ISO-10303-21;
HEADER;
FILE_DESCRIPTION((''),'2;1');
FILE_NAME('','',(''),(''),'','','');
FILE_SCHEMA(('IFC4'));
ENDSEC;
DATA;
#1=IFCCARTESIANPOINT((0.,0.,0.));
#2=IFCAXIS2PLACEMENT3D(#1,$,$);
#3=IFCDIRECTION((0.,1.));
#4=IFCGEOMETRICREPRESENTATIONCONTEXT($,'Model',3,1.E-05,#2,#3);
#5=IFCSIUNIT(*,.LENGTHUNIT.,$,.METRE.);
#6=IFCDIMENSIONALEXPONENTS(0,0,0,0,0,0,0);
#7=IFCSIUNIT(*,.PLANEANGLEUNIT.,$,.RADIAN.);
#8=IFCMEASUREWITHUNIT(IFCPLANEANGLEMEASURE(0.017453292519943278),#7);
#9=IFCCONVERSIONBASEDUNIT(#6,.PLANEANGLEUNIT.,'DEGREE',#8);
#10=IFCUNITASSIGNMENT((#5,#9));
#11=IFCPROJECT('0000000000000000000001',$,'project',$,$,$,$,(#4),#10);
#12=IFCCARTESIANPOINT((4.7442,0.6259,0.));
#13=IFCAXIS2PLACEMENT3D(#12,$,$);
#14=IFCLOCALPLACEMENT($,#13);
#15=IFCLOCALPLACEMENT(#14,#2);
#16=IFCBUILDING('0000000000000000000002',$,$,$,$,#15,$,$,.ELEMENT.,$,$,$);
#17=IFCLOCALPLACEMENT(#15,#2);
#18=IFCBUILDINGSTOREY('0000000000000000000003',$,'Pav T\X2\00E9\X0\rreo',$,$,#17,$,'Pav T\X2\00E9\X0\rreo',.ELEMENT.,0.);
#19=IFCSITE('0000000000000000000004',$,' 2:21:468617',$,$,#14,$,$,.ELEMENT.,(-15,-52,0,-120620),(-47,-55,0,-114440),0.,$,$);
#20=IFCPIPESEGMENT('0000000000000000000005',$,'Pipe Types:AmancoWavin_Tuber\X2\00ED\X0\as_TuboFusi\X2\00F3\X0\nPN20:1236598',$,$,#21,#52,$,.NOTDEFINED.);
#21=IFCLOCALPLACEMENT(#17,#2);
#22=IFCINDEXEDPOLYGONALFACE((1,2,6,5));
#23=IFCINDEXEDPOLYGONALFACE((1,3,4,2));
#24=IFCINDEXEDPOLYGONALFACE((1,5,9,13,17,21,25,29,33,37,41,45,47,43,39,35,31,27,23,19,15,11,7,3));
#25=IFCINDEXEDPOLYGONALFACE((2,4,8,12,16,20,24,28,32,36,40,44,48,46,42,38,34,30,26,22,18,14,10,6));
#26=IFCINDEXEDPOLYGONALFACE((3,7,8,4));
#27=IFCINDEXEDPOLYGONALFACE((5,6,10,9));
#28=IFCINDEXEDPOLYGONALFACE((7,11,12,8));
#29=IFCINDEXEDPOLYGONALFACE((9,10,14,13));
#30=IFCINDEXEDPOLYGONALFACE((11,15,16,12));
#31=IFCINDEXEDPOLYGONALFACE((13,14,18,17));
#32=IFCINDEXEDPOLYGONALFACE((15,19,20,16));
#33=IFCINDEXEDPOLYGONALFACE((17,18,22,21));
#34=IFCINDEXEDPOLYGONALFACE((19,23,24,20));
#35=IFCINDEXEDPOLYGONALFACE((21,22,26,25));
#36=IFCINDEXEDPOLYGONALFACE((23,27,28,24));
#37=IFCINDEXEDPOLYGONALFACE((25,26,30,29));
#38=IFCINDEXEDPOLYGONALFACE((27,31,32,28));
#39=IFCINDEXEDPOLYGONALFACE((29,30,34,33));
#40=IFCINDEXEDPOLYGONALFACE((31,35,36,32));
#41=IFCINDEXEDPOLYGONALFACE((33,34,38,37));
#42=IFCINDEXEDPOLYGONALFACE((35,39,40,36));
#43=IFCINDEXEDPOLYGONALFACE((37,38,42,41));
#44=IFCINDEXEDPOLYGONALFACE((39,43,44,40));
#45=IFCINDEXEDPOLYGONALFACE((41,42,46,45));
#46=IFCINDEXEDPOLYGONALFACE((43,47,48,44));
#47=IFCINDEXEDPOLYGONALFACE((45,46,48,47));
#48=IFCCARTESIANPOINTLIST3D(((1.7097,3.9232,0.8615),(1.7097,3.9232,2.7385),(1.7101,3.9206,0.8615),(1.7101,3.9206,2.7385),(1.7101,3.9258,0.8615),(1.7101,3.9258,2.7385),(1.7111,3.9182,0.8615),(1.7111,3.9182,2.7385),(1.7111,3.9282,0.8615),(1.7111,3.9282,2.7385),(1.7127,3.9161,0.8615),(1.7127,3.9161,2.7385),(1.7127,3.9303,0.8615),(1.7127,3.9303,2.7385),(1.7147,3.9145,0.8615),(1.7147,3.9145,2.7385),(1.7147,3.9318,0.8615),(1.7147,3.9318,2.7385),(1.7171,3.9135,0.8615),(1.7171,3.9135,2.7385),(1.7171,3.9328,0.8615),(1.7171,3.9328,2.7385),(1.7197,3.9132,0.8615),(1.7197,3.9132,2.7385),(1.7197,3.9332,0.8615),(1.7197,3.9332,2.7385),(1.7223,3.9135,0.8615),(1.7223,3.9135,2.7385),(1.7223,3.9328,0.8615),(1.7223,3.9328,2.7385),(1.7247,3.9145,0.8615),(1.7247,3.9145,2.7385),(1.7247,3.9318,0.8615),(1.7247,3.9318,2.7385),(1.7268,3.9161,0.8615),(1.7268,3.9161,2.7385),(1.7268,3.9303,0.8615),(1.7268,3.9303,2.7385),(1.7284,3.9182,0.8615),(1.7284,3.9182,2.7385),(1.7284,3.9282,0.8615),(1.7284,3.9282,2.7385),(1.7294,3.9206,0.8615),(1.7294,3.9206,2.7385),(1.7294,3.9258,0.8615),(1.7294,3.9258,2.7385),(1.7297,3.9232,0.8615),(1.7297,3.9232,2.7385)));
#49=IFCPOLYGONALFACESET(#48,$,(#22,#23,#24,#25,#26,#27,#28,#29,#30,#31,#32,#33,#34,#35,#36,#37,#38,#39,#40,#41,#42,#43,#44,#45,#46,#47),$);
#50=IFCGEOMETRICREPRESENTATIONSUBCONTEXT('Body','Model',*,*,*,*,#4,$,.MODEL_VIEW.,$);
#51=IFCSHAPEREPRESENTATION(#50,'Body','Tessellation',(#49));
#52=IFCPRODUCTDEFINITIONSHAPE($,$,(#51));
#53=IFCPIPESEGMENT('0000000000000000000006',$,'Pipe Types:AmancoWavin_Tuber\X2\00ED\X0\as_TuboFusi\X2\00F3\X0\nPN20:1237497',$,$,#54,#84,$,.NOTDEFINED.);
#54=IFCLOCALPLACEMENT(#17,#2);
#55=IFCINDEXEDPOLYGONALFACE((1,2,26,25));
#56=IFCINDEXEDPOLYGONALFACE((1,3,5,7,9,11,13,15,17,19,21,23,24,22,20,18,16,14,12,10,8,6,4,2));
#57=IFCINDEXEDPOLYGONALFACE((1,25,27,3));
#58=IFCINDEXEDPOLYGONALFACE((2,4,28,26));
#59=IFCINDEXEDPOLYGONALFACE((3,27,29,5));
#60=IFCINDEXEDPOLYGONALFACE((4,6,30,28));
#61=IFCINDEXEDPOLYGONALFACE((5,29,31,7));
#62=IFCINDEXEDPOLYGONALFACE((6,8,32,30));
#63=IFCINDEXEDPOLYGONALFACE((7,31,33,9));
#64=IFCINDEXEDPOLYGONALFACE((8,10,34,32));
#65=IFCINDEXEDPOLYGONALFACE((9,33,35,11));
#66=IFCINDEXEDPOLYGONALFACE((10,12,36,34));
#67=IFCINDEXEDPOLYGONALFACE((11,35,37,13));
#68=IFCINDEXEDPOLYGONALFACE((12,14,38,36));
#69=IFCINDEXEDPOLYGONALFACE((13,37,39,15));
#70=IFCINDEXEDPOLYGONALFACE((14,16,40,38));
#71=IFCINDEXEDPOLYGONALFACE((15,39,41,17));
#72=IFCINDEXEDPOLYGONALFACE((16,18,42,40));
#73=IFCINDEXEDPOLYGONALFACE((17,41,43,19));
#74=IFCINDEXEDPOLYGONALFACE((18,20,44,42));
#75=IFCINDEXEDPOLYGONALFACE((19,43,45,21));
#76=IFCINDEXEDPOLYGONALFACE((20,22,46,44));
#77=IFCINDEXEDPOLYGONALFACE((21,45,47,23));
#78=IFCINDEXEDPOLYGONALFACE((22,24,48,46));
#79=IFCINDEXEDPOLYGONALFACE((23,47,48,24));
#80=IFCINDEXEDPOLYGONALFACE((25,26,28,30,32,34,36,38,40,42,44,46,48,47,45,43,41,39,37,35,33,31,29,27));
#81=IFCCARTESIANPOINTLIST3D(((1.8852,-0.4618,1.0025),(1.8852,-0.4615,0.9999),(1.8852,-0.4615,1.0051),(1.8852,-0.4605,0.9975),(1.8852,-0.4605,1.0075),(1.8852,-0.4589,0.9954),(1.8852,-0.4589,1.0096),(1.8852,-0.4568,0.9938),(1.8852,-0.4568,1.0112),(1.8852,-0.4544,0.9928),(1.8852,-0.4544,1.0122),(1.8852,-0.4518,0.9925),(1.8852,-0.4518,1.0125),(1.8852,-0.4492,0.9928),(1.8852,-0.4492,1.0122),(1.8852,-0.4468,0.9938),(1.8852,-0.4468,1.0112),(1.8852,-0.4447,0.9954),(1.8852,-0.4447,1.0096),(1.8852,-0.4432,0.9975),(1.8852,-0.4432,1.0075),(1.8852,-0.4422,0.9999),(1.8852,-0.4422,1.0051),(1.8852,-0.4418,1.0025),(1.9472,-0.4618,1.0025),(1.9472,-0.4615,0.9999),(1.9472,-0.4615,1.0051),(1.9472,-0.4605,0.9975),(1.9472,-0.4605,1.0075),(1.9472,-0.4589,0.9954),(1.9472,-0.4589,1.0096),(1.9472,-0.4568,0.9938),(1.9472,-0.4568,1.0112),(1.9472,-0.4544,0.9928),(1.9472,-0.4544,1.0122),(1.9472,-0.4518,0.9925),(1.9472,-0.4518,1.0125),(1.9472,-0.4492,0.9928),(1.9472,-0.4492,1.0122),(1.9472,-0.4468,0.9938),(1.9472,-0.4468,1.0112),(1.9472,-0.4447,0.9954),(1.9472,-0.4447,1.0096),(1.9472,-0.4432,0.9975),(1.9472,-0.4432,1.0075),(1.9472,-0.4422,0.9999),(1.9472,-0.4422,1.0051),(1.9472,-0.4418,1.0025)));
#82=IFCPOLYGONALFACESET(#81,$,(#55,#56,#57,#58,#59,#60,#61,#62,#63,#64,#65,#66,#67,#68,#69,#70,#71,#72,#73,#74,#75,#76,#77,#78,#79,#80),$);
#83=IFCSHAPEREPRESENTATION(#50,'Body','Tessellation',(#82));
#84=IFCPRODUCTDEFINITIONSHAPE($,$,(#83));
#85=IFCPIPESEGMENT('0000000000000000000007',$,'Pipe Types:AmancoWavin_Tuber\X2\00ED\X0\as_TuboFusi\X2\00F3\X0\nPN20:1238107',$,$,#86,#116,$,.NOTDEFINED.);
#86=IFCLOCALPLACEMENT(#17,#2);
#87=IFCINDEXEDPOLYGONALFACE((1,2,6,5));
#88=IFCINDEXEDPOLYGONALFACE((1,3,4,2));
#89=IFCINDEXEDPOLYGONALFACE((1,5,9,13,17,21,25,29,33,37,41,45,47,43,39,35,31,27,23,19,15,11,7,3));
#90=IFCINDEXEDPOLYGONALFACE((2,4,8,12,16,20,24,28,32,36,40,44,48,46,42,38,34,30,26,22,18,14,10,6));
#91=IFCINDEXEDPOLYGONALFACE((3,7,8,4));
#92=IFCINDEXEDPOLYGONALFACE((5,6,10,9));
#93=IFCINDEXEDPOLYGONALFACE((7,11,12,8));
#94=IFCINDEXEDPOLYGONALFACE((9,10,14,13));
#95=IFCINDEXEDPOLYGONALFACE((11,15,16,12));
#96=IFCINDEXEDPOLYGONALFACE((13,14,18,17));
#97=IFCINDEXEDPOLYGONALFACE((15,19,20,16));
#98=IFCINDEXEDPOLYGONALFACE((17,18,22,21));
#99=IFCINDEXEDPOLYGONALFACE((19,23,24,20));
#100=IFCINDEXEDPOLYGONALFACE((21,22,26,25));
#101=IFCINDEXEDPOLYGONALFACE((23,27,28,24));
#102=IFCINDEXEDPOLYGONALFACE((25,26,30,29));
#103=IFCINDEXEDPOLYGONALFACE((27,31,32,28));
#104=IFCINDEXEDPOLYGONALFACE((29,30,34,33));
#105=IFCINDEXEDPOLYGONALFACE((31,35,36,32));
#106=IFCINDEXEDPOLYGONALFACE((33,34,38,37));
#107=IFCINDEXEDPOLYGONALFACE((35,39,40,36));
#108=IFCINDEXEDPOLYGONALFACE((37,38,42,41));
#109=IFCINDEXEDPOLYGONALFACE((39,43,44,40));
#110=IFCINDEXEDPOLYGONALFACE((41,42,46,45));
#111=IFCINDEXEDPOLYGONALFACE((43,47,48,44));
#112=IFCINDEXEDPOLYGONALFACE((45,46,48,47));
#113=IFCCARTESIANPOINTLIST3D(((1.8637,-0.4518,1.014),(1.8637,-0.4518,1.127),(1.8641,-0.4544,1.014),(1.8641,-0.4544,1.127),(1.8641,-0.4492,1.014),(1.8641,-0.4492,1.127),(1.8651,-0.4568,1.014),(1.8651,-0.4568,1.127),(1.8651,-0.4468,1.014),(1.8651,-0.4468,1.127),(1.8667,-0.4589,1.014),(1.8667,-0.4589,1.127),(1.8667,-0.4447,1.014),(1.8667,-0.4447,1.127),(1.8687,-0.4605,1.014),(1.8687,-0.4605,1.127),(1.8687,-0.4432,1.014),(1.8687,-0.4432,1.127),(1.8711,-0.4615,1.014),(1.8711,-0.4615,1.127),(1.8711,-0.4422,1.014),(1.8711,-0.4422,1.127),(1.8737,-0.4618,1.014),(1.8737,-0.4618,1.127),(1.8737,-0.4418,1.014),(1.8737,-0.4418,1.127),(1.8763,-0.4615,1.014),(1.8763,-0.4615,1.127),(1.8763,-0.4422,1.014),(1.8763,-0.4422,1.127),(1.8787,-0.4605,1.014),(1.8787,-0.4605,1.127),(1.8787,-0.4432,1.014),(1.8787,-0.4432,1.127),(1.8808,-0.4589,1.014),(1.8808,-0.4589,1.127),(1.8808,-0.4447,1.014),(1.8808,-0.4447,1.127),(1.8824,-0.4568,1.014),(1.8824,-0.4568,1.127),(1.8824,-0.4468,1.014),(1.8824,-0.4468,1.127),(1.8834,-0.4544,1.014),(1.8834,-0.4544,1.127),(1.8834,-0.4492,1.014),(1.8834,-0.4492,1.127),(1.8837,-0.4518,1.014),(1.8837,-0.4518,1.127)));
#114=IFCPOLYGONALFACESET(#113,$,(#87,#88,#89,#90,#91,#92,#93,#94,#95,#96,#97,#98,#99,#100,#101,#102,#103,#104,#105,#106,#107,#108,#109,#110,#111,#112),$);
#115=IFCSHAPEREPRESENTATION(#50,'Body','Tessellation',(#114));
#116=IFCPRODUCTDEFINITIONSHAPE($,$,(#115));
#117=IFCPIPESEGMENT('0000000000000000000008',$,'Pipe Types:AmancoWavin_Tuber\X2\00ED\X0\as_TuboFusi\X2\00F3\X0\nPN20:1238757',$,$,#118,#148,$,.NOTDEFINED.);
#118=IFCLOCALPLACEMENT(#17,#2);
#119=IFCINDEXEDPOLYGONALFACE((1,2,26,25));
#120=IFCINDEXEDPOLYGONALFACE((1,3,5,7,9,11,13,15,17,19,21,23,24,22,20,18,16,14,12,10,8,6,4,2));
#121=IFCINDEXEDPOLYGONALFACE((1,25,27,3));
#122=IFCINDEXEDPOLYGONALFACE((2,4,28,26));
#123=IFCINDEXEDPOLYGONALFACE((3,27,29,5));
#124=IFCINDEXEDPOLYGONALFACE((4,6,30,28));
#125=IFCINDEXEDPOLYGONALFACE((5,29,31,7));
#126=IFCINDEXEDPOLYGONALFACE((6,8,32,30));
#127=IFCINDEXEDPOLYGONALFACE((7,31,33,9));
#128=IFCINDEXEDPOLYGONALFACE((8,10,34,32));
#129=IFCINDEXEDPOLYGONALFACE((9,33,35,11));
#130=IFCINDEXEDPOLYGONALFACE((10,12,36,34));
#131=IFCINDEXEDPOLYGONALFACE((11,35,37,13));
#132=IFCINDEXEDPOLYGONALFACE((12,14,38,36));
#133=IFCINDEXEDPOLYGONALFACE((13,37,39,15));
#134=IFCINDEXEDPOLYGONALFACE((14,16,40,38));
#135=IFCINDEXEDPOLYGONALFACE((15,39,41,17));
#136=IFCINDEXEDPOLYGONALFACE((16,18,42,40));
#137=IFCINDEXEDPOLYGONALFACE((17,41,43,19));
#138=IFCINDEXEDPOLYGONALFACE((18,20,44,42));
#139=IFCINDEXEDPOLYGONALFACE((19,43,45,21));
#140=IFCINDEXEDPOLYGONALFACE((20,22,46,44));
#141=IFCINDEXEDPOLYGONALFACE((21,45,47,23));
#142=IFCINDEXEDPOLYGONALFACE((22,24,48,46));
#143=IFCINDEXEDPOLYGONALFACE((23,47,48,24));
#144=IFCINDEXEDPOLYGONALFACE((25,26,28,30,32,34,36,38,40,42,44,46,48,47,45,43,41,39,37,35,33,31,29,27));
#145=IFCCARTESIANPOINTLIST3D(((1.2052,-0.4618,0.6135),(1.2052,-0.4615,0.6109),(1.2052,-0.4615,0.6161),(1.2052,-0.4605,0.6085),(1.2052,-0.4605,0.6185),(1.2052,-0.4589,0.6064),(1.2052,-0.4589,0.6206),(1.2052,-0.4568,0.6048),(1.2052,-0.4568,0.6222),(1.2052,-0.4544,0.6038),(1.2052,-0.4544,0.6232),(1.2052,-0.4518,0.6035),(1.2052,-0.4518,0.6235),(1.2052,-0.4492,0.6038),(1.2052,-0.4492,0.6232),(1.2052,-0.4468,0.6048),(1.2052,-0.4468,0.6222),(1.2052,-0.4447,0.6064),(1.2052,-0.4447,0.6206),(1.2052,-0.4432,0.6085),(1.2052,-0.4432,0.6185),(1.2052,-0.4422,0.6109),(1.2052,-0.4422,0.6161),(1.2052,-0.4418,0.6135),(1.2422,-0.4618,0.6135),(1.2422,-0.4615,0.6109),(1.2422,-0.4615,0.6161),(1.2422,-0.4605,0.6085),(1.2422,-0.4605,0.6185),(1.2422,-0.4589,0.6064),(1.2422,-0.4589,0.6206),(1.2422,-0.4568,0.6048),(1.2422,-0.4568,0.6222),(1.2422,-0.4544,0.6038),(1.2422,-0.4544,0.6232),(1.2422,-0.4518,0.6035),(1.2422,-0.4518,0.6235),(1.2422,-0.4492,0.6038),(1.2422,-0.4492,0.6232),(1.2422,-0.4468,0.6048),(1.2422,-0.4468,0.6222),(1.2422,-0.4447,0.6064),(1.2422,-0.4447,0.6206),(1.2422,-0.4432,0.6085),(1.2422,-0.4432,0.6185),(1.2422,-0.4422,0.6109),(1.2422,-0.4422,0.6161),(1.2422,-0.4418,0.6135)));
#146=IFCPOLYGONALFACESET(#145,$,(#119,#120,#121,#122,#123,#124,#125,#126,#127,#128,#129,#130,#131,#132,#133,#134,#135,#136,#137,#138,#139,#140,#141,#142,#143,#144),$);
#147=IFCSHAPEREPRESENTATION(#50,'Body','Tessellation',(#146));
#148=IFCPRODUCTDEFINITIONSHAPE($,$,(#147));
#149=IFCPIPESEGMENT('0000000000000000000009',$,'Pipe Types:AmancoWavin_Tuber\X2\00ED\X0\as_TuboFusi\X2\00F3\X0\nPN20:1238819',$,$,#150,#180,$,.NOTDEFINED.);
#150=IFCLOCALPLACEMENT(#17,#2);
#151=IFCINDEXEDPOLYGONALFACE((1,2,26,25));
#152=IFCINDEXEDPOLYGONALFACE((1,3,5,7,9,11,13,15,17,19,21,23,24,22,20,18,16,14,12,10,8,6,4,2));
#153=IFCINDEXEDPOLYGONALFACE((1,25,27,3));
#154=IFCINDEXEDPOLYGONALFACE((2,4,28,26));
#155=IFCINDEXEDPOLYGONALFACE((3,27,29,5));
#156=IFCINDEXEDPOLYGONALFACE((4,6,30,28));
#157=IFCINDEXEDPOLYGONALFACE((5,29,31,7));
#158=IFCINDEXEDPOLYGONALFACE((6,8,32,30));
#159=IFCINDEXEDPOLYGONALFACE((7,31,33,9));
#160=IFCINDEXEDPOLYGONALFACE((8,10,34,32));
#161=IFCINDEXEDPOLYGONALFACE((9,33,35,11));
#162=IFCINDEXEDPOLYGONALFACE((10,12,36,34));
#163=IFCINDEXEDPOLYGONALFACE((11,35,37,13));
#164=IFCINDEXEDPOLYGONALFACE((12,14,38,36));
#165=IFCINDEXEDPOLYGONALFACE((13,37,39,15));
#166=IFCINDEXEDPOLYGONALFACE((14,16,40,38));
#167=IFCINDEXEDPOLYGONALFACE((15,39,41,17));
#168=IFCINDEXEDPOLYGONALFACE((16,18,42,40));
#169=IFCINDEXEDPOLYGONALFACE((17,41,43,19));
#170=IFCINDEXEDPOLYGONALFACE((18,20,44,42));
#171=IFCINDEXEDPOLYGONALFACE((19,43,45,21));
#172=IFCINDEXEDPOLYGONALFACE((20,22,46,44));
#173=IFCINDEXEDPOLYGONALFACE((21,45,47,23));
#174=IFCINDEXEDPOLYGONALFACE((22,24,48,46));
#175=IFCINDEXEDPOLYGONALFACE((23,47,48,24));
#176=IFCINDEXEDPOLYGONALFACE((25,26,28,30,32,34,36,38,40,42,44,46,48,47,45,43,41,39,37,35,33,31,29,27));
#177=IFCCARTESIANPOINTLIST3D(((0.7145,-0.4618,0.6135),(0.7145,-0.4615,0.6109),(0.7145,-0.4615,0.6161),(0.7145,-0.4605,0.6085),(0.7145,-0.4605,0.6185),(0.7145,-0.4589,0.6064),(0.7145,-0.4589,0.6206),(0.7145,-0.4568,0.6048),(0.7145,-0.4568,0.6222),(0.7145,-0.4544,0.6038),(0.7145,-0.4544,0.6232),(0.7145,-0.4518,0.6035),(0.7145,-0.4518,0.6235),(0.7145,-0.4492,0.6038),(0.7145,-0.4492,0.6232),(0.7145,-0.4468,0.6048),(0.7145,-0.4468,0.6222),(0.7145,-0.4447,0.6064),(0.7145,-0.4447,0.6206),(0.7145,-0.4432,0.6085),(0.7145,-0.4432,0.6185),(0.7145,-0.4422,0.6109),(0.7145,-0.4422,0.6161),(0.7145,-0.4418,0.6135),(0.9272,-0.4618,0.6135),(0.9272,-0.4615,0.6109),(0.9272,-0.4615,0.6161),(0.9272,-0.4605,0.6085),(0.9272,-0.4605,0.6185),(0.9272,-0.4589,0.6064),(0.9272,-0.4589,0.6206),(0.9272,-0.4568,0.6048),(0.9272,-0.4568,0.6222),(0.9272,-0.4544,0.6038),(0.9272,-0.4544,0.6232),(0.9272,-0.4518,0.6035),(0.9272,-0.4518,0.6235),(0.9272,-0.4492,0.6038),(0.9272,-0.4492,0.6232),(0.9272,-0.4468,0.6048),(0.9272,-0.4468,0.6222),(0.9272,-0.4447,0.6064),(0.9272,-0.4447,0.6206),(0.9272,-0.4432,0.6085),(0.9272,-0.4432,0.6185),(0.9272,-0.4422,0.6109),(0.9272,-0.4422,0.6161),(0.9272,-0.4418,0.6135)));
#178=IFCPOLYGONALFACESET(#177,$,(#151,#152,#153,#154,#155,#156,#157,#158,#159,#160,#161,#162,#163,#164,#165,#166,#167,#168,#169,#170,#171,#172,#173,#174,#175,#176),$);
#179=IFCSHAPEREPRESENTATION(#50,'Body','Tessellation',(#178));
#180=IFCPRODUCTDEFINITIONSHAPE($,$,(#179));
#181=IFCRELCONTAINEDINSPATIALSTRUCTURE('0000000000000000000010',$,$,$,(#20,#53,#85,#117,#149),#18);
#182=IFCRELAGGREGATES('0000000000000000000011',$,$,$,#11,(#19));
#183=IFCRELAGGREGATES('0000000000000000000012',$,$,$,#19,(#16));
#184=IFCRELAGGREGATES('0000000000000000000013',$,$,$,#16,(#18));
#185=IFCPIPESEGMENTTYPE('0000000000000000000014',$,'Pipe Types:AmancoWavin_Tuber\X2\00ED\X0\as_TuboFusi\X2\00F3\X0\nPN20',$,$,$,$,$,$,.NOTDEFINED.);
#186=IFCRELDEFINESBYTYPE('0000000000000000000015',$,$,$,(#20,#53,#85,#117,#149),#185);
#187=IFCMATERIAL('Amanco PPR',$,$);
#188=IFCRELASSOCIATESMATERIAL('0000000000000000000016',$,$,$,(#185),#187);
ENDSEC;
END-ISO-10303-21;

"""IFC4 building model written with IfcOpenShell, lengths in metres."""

from ifc_helpers import new_model, entity, si_unit, converted_unit, direction, frame, origin, place, context, subcontext, project, spatial, arc, indexed_curve, outline, extrude, material, type_object, element, save


model = new_model("IFC4")

# Units and contexts
model_context = context("Model", 3, precision=1e-05, world=origin(), true_north=direction((0.0, 1.0)))
body_context = subcontext(model_context, "Body", "Model", "MODEL_VIEW")
ifc_project = project(units=[si_unit("LENGTHUNIT", "METRE"), converted_unit("PLANEANGLEUNIT", "DEGREE", entity("IfcPlaneAngleMeasure", 0.017453292519943278), si_unit("PLANEANGLEUNIT", "RADIAN"), dimensions=[0, 0, 0, 0, 0, 0, 0])], contexts=[model_context])

# Site, building, storey
site_placement = place(None, frame((4.7442, 0.6259, 0.0)))
site = spatial("IfcSite", under=ifc_project, at=site_placement, Name=" 2:21:468617", CompositionType="ELEMENT", RefLatitude=(-15, -52, 0, -120620), RefLongitude=(-47, -55, 0, -114440), RefElevation=0.0)
building_placement = place(site_placement, origin())
building = spatial("IfcBuilding", under=site, at=building_placement, CompositionType="ELEMENT")
storey_placement = place(building_placement, origin())
storey = spatial("IfcBuildingStorey", under=building, at=storey_placement, Name="Pav Térreo", LongName="Pav Térreo", CompositionType="ELEMENT", Elevation=0.0)

# Pipe segments
ifc_material_1 = material(Name="Amanco PPR")
pipe_segment_type_1 = type_object("IfcPipeSegmentType", Name="Pipe Types:AmancoWavin_Tuberías_TuboFusiónPN20", PredefinedType="NOTDEFINED", material=ifc_material_1)
pipe_segment_1_placement = place(storey_placement, origin())
element("IfcPipeSegment", 1, at=pipe_segment_1_placement, inside=storey, type_object=pipe_segment_type_1, Name="Pipe Types:AmancoWavin_Tuberías_TuboFusiónPN20:1236598", PredefinedType="NOTDEFINED", context=body_context, shape_type="SweptSolid", body=[
    extrude(outline(indexed_curve([(0.01, 0.0), (0.0071, 0.0071), (0.0, 0.01), (-0.0071, 0.0071), (-0.01, 0.0), (-0.0071, -0.0071), (0.0, -0.01), (0.0071, -0.0071)], segments=[arc(1, 2, 3), arc(3, 4, 5), arc(5, 6, 7), arc(7, 8, 1)], self_intersect=False)), frame((1.7197, 3.9232, 0.8615)), (0.0, 0.0, 1.0), 1.877),
])
pipe_segment_2_placement = place(storey_placement, origin())
element("IfcPipeSegment", 2, at=pipe_segment_2_placement, inside=storey, type_object=pipe_segment_type_1, Name="Pipe Types:AmancoWavin_Tuberías_TuboFusiónPN20:1237497", PredefinedType="NOTDEFINED", context=body_context, shape_type="SweptSolid", body=[
    extrude(outline(indexed_curve([(0.01, 0.0), (0.0071, 0.0071), (0.0, 0.01), (-0.0071, 0.0071), (-0.01, 0.0), (-0.0071, -0.0071), (0.0, -0.01), (0.0071, -0.0071)], segments=[arc(1, 2, 3), arc(3, 4, 5), arc(5, 6, 7), arc(7, 8, 1)], self_intersect=False)), frame((1.8852, -0.4518, 1.0025), z_axis=(1.0, 0.0, 0.0), x_axis=(0.0, 1.0, 0.0)), (0.0, 0.0, 1.0), 0.062),
])
pipe_segment_3_placement = place(storey_placement, origin())
element("IfcPipeSegment", 3, at=pipe_segment_3_placement, inside=storey, type_object=pipe_segment_type_1, Name="Pipe Types:AmancoWavin_Tuberías_TuboFusiónPN20:1238107", PredefinedType="NOTDEFINED", context=body_context, shape_type="SweptSolid", body=[
    extrude(outline(indexed_curve([(0.01, 0.0), (0.0071, 0.0071), (0.0, 0.01), (-0.0071, 0.0071), (-0.01, 0.0), (-0.0071, -0.0071), (0.0, -0.01), (0.0071, -0.0071)], segments=[arc(1, 2, 3), arc(3, 4, 5), arc(5, 6, 7), arc(7, 8, 1)], self_intersect=False)), frame((1.8737, -0.4518, 1.014), z_axis=(0.0, 0.0, 1.0), x_axis=(-1.0, 0.0, 0.0)), (0.0, 0.0, 1.0), 0.113),
])
pipe_segment_4_placement = place(storey_placement, origin())
element("IfcPipeSegment", 4, at=pipe_segment_4_placement, inside=storey, type_object=pipe_segment_type_1, Name="Pipe Types:AmancoWavin_Tuberías_TuboFusiónPN20:1238757", PredefinedType="NOTDEFINED", context=body_context, shape_type="SweptSolid", body=[
    extrude(outline(indexed_curve([(0.01, 0.0), (0.0071, 0.0071), (0.0, 0.01), (-0.0071, 0.0071), (-0.01, 0.0), (-0.0071, -0.0071), (0.0, -0.01), (0.0071, -0.0071)], segments=[arc(1, 2, 3), arc(3, 4, 5), arc(5, 6, 7), arc(7, 8, 1)], self_intersect=False)), frame((1.2052, -0.4518, 0.6135), z_axis=(1.0, 0.0, 0.0), x_axis=(0.0, 1.0, 0.0)), (0.0, 0.0, 1.0), 0.037),
])
pipe_segment_5_placement = place(storey_placement, origin())
element("IfcPipeSegment", 5, at=pipe_segment_5_placement, inside=storey, type_object=pipe_segment_type_1, Name="Pipe Types:AmancoWavin_Tuberías_TuboFusiónPN20:1238819", PredefinedType="NOTDEFINED", context=body_context, shape_type="SweptSolid", body=[
    extrude(outline(indexed_curve([(0.01, 0.0), (0.0071, 0.0071), (0.0, 0.01), (-0.0071, 0.0071), (-0.01, 0.0), (-0.0071, -0.0071), (0.0, -0.01), (0.0071, -0.0071)], segments=[arc(1, 2, 3), arc(3, 4, 5), arc(5, 6, 7), arc(7, 8, 1)], self_intersect=False)), frame((0.7145, -0.4518, 0.6135), z_axis=(1.0, 0.0, 0.0), x_axis=(0.0, 1.0, 0.0)), (0.0, 0.0, 1.0), 0.2127),
])

save(model, "model.ifc")
